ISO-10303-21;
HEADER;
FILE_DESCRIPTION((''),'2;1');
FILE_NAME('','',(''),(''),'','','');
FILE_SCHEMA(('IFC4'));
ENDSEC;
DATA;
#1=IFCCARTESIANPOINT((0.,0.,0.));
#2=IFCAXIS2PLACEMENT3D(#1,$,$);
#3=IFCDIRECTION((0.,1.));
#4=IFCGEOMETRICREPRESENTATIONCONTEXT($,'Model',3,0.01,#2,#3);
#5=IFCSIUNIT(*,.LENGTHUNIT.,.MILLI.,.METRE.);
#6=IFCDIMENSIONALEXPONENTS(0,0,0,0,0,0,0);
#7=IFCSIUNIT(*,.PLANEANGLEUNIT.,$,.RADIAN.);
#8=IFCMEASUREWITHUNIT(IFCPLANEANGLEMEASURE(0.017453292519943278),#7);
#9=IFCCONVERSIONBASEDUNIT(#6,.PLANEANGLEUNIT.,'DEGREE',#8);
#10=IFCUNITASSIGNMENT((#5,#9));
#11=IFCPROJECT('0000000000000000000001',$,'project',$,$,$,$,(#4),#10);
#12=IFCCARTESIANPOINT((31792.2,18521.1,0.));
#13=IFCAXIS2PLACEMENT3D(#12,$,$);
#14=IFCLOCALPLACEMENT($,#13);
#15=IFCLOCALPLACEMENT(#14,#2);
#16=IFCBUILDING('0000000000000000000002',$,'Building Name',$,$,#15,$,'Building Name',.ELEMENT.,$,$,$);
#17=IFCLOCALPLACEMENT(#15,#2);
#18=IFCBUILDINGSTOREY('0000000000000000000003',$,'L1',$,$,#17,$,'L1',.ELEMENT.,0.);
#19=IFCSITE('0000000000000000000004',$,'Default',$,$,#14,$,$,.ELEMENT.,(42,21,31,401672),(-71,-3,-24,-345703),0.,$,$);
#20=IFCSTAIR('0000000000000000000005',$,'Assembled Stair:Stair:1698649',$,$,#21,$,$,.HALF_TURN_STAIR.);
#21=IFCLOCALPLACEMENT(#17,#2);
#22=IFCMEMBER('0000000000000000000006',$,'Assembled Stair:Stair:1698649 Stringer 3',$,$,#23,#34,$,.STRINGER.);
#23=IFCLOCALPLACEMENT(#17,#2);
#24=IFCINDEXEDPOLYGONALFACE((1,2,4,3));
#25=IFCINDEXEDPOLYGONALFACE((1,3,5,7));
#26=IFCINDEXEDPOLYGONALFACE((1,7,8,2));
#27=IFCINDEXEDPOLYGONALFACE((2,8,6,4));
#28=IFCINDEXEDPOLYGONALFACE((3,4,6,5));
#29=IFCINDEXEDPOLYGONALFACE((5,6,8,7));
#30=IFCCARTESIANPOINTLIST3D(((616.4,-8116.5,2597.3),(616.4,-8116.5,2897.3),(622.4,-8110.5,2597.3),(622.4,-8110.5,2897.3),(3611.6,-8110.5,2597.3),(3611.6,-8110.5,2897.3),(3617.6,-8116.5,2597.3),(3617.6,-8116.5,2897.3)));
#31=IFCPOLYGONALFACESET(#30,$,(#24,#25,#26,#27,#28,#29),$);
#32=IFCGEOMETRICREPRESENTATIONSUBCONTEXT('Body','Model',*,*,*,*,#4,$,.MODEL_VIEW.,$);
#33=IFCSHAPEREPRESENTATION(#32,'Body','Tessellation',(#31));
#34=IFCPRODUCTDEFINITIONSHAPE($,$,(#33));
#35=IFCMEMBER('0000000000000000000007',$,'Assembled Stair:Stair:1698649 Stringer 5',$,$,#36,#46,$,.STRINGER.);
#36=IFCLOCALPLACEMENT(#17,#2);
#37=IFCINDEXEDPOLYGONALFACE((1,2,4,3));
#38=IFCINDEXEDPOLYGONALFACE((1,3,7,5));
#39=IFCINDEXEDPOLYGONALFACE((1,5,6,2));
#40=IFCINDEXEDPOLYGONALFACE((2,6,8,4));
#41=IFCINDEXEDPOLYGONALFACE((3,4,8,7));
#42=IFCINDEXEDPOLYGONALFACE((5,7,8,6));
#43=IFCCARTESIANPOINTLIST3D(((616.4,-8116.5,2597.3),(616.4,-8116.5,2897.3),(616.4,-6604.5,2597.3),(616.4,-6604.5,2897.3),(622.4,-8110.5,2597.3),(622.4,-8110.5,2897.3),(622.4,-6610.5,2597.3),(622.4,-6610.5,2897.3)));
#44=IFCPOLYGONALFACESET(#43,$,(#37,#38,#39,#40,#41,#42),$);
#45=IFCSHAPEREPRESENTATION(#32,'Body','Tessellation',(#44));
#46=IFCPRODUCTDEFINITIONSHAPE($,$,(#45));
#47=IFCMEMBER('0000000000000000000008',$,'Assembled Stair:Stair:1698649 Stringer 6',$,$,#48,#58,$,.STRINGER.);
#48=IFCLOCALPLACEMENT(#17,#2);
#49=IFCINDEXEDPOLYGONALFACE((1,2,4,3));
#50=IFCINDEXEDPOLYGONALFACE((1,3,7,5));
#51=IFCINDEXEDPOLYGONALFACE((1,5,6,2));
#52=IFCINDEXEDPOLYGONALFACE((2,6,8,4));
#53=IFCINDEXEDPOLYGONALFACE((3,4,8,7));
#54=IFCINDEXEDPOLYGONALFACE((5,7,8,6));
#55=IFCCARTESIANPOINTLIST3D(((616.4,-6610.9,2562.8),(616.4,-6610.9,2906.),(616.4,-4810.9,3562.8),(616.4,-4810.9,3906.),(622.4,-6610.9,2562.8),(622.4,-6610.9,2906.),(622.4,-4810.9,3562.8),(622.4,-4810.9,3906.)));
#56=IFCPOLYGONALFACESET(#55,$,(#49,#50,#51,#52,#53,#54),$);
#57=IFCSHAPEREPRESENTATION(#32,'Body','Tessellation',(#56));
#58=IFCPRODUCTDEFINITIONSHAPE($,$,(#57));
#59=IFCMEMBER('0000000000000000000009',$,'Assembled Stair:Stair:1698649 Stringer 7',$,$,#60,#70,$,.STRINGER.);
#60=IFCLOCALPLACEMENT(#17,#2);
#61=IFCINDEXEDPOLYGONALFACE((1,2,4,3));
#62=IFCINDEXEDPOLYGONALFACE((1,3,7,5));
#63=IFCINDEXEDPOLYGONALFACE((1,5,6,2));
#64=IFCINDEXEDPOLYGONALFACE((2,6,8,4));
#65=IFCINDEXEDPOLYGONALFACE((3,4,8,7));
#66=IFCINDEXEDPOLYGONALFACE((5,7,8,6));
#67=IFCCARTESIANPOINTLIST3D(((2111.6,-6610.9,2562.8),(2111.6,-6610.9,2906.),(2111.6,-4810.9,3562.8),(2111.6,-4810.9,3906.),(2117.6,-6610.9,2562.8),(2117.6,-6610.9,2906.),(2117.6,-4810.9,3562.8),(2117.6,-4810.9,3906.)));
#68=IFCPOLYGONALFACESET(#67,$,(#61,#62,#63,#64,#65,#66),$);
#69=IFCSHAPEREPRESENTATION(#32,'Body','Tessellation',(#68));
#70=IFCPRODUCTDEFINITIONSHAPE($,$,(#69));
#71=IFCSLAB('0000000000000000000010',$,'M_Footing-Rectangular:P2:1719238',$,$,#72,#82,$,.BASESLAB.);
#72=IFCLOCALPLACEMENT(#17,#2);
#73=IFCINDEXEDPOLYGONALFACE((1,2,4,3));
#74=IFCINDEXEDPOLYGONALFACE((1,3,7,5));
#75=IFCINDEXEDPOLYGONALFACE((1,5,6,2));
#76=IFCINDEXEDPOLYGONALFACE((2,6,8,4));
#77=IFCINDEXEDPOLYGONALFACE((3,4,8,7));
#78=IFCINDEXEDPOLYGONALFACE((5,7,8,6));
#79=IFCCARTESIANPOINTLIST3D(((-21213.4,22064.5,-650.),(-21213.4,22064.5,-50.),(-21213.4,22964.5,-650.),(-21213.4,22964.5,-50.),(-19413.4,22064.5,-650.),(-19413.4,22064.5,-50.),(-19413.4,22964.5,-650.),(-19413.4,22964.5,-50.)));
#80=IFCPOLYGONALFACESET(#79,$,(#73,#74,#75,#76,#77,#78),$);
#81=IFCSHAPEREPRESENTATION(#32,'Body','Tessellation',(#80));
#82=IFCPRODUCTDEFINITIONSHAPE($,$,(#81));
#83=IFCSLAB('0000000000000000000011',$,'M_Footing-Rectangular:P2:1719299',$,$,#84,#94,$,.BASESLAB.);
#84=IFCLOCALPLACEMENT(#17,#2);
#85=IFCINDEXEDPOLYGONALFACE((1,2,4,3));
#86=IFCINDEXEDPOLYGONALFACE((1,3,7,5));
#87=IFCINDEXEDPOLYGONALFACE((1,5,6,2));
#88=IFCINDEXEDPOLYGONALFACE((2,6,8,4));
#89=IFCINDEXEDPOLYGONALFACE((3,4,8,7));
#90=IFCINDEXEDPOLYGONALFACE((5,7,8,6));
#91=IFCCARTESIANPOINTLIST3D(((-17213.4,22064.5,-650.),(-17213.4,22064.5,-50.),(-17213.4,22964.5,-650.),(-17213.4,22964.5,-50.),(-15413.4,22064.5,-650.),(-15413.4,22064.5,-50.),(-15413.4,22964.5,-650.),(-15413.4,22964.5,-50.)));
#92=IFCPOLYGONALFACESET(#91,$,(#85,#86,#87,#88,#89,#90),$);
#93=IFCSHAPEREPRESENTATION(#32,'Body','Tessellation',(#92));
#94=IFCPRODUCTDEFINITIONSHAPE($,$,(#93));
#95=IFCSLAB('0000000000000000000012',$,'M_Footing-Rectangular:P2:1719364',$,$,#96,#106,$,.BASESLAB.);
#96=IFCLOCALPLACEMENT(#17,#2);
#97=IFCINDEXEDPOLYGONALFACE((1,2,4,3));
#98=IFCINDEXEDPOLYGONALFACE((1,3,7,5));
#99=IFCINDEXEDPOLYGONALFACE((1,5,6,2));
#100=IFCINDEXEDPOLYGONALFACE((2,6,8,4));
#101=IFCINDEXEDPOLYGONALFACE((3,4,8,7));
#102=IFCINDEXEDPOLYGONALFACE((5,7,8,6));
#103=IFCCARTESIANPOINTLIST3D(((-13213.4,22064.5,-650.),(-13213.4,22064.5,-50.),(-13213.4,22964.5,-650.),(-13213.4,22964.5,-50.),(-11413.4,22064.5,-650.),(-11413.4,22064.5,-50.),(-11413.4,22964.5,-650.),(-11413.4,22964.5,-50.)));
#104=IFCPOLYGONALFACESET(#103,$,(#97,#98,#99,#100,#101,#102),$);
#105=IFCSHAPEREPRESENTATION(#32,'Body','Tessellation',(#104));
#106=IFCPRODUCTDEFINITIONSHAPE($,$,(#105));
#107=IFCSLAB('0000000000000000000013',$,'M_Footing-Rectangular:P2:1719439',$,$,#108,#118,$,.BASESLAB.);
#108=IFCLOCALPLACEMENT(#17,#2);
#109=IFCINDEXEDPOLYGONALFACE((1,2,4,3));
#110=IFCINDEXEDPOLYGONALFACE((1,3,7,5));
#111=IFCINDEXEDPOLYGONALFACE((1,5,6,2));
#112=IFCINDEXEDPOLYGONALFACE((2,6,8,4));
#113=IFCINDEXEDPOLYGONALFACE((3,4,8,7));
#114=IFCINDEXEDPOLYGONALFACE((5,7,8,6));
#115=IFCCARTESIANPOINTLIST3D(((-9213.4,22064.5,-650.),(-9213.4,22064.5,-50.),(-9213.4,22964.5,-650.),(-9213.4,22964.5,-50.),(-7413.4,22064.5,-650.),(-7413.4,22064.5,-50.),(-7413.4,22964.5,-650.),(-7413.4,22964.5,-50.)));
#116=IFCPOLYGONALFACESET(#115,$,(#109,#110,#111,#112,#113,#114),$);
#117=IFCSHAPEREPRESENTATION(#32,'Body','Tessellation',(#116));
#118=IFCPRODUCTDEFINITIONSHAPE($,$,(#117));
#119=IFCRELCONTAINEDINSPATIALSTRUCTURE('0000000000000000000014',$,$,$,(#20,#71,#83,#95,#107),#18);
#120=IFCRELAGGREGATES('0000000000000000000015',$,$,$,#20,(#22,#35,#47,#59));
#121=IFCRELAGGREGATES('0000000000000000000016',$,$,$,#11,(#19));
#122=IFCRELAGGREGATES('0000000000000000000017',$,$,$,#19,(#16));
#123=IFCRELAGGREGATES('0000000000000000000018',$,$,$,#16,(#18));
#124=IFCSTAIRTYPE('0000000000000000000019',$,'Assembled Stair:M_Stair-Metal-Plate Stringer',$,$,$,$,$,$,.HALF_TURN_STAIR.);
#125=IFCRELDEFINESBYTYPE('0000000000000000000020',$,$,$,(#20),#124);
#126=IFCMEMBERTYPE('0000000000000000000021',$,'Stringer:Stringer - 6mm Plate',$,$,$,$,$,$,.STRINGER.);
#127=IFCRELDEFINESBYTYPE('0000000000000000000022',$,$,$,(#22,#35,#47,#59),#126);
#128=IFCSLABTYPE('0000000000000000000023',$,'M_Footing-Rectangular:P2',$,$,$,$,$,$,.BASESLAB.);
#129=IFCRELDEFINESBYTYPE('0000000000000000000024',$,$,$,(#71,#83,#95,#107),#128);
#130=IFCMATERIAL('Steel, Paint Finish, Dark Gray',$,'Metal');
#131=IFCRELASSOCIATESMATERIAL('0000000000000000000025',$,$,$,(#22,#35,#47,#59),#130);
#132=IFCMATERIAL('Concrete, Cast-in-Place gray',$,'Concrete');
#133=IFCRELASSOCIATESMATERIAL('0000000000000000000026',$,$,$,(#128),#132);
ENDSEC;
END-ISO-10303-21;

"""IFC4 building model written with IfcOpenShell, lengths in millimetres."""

from ifc_helpers import new_model, entity, si_unit, converted_unit, direction, frame, origin, place, context, subcontext, project, spatial, indexed_curve, outline, extrude, material, type_object, element, aggregate, save


model = new_model("IFC4")

# Units and contexts
model_context = context("Model", 3, precision=0.01, world=origin(), true_north=direction((0.0, 1.0)))
body_context = subcontext(model_context, "Body", "Model", "MODEL_VIEW")
ifc_project = project(units=[si_unit("LENGTHUNIT", "METRE", prefix="MILLI"), converted_unit("PLANEANGLEUNIT", "DEGREE", entity("IfcPlaneAngleMeasure", 0.017453292519943278), si_unit("PLANEANGLEUNIT", "RADIAN"), dimensions=[0, 0, 0, 0, 0, 0, 0])], contexts=[model_context])

# Site, building, storey
site_placement = place(None, frame((31792.2, 18521.1, 0.0)))
site = spatial("IfcSite", under=ifc_project, at=site_placement, Name="Default", CompositionType="ELEMENT", RefLatitude=(42, 21, 31, 401672), RefLongitude=(-71, -3, -24, -345703), RefElevation=0.0)
building_placement = place(site_placement, origin())
building = spatial("IfcBuilding", under=site, at=building_placement, Name="Building Name", LongName="Building Name", CompositionType="ELEMENT")
storey_placement = place(building_placement, origin())
storey = spatial("IfcBuildingStorey", under=building, at=storey_placement, Name="L1", LongName="L1", CompositionType="ELEMENT", Elevation=0.0)

# Stair, members
stair_type = type_object("IfcStairType", Name="Assembled Stair:M_Stair-Metal-Plate Stringer", PredefinedType="HALF_TURN_STAIR")
stair_placement = place(storey_placement, origin())
stair = element("IfcStair", 1, at=stair_placement, inside=storey, type_object=stair_type, Name="Assembled Stair:Stair:1698649", PredefinedType="HALF_TURN_STAIR")
ifc_material_1 = material(Name="Steel, Paint Finish, Dark Gray", Category="Metal")
member_type = type_object("IfcMemberType", Name="Stringer:Stringer - 6mm Plate", PredefinedType="STRINGER")
member_1_placement = place(stair_placement, origin())
member_1 = element("IfcMember", 2, at=member_1_placement, type_object=member_type, material=ifc_material_1, Name="Assembled Stair:Stair:1698649 Stringer 3", PredefinedType="STRINGER", context=body_context, shape_type="SweptSolid", body=[
    extrude(outline(indexed_curve([(-1500.6, -3.0), (1500.6, -3.0), (1494.6, 3.0), (-1494.6, 3.0), (-1500.6, -3.0)], self_intersect=False)), frame((2117.0, -8113.5, 2597.3)), (0.0, 0.0, 1.0), 300.0),
])
member_2_placement = place(stair_placement, origin())
member_2 = element("IfcMember", 3, at=member_2_placement, type_object=member_type, material=ifc_material_1, Name="Assembled Stair:Stair:1698649 Stringer 5", PredefinedType="STRINGER", context=body_context, shape_type="SweptSolid", body=[
    extrude(outline(indexed_curve([(-756.0, -3.0), (756.0, -3.0), (750.0, 3.0), (-750.0, 3.0), (-756.0, -3.0)], self_intersect=False)), frame((619.4, -7360.5, 2597.3), z_axis=(0.0, 0.0, 1.0), x_axis=(0.0, -1.0, 0.0)), (0.0, 0.0, 1.0), 300.0),
])
member_3_placement = place(stair_placement, origin())
member_3 = element("IfcMember", 4, at=member_3_placement, type_object=member_type, material=ifc_material_1, Name="Assembled Stair:Stair:1698649 Stringer 6", PredefinedType="STRINGER", context=body_context, shape_type="SweptSolid", body=[
    extrude(outline(indexed_curve([(-1112.9, -150.0), (946.2, -150.0), (1112.9, 150.0), (-946.2, 150.0), (-1112.9, -150.0)], self_intersect=False)), frame((616.4, -5710.9, 3234.4), z_axis=(1.0, 0.0, 0.0), x_axis=(0.0, 0.874157, 0.485643)), (0.0, 0.0, 1.0), 6.0),
])
member_4_placement = place(stair_placement, origin())
member_4 = element("IfcMember", 5, at=member_4_placement, type_object=member_type, material=ifc_material_1, Name="Assembled Stair:Stair:1698649 Stringer 7", PredefinedType="STRINGER", context=body_context, shape_type="SweptSolid", body=[
    extrude(outline(indexed_curve([(-1112.9, -150.0), (946.2, -150.0), (1112.9, 150.0), (-946.2, 150.0), (-1112.9, -150.0)], self_intersect=False)), frame((2111.6, -5710.9, 3234.4), z_axis=(1.0, 0.0, 0.0), x_axis=(0.0, 0.874157, 0.485643)), (0.0, 0.0, 1.0), 6.0),
])

# Slabs
ifc_material_2 = material(Name="Concrete, Cast-in-Place gray", Category="Concrete")
slab_type_1 = type_object("IfcSlabType", Name="M_Footing-Rectangular:P2", PredefinedType="BASESLAB", material=ifc_material_2)
slab_1_placement = place(storey_placement, origin())
element("IfcSlab", 6, at=slab_1_placement, inside=storey, type_object=slab_type_1, Name="M_Footing-Rectangular:P2:1719238", PredefinedType="BASESLAB", context=body_context, shape_type="SweptSolid", body=[
    extrude(outline(indexed_curve([(-450.0, -900.0), (450.0, -900.0), (450.0, 900.0), (-450.0, 900.0), (-450.0, -900.0)], self_intersect=False)), frame((-20313.4, 22514.5, -650.0), z_axis=(0.0, 0.0, 1.0), x_axis=(0.0, -1.0, 0.0)), (0.0, 0.0, 1.0), 600.0),
])
slab_2_placement = place(storey_placement, origin())
element("IfcSlab", 7, at=slab_2_placement, inside=storey, type_object=slab_type_1, Name="M_Footing-Rectangular:P2:1719299", PredefinedType="BASESLAB", context=body_context, shape_type="SweptSolid", body=[
    extrude(outline(indexed_curve([(-450.0, -900.0), (450.0, -900.0), (450.0, 900.0), (-450.0, 900.0), (-450.0, -900.0)], self_intersect=False)), frame((-16313.4, 22514.5, -650.0), z_axis=(0.0, 0.0, 1.0), x_axis=(0.0, -1.0, 0.0)), (0.0, 0.0, 1.0), 600.0),
])
slab_3_placement = place(storey_placement, origin())
element("IfcSlab", 8, at=slab_3_placement, inside=storey, type_object=slab_type_1, Name="M_Footing-Rectangular:P2:1719364", PredefinedType="BASESLAB", context=body_context, shape_type="SweptSolid", body=[
    extrude(outline(indexed_curve([(-450.0, -900.0), (450.0, -900.0), (450.0, 900.0), (-450.0, 900.0), (-450.0, -900.0)], self_intersect=False)), frame((-12313.4, 22514.5, -650.0), z_axis=(0.0, 0.0, 1.0), x_axis=(0.0, -1.0, 0.0)), (0.0, 0.0, 1.0), 600.0),
])
slab_4_placement = place(storey_placement, origin())
element("IfcSlab", 9, at=slab_4_placement, inside=storey, type_object=slab_type_1, Name="M_Footing-Rectangular:P2:1719439", PredefinedType="BASESLAB", context=body_context, shape_type="SweptSolid", body=[
    extrude(outline(indexed_curve([(-450.0, -900.0), (450.0, -900.0), (450.0, 900.0), (-450.0, 900.0), (-450.0, -900.0)], self_intersect=False)), frame((-8313.4, 22514.5, -650.0), z_axis=(0.0, 0.0, 1.0), x_axis=(0.0, -1.0, 0.0)), (0.0, 0.0, 1.0), 600.0),
])

aggregate(stair, [member_1, member_2, member_3, member_4])

save(model, "model.ifc")
